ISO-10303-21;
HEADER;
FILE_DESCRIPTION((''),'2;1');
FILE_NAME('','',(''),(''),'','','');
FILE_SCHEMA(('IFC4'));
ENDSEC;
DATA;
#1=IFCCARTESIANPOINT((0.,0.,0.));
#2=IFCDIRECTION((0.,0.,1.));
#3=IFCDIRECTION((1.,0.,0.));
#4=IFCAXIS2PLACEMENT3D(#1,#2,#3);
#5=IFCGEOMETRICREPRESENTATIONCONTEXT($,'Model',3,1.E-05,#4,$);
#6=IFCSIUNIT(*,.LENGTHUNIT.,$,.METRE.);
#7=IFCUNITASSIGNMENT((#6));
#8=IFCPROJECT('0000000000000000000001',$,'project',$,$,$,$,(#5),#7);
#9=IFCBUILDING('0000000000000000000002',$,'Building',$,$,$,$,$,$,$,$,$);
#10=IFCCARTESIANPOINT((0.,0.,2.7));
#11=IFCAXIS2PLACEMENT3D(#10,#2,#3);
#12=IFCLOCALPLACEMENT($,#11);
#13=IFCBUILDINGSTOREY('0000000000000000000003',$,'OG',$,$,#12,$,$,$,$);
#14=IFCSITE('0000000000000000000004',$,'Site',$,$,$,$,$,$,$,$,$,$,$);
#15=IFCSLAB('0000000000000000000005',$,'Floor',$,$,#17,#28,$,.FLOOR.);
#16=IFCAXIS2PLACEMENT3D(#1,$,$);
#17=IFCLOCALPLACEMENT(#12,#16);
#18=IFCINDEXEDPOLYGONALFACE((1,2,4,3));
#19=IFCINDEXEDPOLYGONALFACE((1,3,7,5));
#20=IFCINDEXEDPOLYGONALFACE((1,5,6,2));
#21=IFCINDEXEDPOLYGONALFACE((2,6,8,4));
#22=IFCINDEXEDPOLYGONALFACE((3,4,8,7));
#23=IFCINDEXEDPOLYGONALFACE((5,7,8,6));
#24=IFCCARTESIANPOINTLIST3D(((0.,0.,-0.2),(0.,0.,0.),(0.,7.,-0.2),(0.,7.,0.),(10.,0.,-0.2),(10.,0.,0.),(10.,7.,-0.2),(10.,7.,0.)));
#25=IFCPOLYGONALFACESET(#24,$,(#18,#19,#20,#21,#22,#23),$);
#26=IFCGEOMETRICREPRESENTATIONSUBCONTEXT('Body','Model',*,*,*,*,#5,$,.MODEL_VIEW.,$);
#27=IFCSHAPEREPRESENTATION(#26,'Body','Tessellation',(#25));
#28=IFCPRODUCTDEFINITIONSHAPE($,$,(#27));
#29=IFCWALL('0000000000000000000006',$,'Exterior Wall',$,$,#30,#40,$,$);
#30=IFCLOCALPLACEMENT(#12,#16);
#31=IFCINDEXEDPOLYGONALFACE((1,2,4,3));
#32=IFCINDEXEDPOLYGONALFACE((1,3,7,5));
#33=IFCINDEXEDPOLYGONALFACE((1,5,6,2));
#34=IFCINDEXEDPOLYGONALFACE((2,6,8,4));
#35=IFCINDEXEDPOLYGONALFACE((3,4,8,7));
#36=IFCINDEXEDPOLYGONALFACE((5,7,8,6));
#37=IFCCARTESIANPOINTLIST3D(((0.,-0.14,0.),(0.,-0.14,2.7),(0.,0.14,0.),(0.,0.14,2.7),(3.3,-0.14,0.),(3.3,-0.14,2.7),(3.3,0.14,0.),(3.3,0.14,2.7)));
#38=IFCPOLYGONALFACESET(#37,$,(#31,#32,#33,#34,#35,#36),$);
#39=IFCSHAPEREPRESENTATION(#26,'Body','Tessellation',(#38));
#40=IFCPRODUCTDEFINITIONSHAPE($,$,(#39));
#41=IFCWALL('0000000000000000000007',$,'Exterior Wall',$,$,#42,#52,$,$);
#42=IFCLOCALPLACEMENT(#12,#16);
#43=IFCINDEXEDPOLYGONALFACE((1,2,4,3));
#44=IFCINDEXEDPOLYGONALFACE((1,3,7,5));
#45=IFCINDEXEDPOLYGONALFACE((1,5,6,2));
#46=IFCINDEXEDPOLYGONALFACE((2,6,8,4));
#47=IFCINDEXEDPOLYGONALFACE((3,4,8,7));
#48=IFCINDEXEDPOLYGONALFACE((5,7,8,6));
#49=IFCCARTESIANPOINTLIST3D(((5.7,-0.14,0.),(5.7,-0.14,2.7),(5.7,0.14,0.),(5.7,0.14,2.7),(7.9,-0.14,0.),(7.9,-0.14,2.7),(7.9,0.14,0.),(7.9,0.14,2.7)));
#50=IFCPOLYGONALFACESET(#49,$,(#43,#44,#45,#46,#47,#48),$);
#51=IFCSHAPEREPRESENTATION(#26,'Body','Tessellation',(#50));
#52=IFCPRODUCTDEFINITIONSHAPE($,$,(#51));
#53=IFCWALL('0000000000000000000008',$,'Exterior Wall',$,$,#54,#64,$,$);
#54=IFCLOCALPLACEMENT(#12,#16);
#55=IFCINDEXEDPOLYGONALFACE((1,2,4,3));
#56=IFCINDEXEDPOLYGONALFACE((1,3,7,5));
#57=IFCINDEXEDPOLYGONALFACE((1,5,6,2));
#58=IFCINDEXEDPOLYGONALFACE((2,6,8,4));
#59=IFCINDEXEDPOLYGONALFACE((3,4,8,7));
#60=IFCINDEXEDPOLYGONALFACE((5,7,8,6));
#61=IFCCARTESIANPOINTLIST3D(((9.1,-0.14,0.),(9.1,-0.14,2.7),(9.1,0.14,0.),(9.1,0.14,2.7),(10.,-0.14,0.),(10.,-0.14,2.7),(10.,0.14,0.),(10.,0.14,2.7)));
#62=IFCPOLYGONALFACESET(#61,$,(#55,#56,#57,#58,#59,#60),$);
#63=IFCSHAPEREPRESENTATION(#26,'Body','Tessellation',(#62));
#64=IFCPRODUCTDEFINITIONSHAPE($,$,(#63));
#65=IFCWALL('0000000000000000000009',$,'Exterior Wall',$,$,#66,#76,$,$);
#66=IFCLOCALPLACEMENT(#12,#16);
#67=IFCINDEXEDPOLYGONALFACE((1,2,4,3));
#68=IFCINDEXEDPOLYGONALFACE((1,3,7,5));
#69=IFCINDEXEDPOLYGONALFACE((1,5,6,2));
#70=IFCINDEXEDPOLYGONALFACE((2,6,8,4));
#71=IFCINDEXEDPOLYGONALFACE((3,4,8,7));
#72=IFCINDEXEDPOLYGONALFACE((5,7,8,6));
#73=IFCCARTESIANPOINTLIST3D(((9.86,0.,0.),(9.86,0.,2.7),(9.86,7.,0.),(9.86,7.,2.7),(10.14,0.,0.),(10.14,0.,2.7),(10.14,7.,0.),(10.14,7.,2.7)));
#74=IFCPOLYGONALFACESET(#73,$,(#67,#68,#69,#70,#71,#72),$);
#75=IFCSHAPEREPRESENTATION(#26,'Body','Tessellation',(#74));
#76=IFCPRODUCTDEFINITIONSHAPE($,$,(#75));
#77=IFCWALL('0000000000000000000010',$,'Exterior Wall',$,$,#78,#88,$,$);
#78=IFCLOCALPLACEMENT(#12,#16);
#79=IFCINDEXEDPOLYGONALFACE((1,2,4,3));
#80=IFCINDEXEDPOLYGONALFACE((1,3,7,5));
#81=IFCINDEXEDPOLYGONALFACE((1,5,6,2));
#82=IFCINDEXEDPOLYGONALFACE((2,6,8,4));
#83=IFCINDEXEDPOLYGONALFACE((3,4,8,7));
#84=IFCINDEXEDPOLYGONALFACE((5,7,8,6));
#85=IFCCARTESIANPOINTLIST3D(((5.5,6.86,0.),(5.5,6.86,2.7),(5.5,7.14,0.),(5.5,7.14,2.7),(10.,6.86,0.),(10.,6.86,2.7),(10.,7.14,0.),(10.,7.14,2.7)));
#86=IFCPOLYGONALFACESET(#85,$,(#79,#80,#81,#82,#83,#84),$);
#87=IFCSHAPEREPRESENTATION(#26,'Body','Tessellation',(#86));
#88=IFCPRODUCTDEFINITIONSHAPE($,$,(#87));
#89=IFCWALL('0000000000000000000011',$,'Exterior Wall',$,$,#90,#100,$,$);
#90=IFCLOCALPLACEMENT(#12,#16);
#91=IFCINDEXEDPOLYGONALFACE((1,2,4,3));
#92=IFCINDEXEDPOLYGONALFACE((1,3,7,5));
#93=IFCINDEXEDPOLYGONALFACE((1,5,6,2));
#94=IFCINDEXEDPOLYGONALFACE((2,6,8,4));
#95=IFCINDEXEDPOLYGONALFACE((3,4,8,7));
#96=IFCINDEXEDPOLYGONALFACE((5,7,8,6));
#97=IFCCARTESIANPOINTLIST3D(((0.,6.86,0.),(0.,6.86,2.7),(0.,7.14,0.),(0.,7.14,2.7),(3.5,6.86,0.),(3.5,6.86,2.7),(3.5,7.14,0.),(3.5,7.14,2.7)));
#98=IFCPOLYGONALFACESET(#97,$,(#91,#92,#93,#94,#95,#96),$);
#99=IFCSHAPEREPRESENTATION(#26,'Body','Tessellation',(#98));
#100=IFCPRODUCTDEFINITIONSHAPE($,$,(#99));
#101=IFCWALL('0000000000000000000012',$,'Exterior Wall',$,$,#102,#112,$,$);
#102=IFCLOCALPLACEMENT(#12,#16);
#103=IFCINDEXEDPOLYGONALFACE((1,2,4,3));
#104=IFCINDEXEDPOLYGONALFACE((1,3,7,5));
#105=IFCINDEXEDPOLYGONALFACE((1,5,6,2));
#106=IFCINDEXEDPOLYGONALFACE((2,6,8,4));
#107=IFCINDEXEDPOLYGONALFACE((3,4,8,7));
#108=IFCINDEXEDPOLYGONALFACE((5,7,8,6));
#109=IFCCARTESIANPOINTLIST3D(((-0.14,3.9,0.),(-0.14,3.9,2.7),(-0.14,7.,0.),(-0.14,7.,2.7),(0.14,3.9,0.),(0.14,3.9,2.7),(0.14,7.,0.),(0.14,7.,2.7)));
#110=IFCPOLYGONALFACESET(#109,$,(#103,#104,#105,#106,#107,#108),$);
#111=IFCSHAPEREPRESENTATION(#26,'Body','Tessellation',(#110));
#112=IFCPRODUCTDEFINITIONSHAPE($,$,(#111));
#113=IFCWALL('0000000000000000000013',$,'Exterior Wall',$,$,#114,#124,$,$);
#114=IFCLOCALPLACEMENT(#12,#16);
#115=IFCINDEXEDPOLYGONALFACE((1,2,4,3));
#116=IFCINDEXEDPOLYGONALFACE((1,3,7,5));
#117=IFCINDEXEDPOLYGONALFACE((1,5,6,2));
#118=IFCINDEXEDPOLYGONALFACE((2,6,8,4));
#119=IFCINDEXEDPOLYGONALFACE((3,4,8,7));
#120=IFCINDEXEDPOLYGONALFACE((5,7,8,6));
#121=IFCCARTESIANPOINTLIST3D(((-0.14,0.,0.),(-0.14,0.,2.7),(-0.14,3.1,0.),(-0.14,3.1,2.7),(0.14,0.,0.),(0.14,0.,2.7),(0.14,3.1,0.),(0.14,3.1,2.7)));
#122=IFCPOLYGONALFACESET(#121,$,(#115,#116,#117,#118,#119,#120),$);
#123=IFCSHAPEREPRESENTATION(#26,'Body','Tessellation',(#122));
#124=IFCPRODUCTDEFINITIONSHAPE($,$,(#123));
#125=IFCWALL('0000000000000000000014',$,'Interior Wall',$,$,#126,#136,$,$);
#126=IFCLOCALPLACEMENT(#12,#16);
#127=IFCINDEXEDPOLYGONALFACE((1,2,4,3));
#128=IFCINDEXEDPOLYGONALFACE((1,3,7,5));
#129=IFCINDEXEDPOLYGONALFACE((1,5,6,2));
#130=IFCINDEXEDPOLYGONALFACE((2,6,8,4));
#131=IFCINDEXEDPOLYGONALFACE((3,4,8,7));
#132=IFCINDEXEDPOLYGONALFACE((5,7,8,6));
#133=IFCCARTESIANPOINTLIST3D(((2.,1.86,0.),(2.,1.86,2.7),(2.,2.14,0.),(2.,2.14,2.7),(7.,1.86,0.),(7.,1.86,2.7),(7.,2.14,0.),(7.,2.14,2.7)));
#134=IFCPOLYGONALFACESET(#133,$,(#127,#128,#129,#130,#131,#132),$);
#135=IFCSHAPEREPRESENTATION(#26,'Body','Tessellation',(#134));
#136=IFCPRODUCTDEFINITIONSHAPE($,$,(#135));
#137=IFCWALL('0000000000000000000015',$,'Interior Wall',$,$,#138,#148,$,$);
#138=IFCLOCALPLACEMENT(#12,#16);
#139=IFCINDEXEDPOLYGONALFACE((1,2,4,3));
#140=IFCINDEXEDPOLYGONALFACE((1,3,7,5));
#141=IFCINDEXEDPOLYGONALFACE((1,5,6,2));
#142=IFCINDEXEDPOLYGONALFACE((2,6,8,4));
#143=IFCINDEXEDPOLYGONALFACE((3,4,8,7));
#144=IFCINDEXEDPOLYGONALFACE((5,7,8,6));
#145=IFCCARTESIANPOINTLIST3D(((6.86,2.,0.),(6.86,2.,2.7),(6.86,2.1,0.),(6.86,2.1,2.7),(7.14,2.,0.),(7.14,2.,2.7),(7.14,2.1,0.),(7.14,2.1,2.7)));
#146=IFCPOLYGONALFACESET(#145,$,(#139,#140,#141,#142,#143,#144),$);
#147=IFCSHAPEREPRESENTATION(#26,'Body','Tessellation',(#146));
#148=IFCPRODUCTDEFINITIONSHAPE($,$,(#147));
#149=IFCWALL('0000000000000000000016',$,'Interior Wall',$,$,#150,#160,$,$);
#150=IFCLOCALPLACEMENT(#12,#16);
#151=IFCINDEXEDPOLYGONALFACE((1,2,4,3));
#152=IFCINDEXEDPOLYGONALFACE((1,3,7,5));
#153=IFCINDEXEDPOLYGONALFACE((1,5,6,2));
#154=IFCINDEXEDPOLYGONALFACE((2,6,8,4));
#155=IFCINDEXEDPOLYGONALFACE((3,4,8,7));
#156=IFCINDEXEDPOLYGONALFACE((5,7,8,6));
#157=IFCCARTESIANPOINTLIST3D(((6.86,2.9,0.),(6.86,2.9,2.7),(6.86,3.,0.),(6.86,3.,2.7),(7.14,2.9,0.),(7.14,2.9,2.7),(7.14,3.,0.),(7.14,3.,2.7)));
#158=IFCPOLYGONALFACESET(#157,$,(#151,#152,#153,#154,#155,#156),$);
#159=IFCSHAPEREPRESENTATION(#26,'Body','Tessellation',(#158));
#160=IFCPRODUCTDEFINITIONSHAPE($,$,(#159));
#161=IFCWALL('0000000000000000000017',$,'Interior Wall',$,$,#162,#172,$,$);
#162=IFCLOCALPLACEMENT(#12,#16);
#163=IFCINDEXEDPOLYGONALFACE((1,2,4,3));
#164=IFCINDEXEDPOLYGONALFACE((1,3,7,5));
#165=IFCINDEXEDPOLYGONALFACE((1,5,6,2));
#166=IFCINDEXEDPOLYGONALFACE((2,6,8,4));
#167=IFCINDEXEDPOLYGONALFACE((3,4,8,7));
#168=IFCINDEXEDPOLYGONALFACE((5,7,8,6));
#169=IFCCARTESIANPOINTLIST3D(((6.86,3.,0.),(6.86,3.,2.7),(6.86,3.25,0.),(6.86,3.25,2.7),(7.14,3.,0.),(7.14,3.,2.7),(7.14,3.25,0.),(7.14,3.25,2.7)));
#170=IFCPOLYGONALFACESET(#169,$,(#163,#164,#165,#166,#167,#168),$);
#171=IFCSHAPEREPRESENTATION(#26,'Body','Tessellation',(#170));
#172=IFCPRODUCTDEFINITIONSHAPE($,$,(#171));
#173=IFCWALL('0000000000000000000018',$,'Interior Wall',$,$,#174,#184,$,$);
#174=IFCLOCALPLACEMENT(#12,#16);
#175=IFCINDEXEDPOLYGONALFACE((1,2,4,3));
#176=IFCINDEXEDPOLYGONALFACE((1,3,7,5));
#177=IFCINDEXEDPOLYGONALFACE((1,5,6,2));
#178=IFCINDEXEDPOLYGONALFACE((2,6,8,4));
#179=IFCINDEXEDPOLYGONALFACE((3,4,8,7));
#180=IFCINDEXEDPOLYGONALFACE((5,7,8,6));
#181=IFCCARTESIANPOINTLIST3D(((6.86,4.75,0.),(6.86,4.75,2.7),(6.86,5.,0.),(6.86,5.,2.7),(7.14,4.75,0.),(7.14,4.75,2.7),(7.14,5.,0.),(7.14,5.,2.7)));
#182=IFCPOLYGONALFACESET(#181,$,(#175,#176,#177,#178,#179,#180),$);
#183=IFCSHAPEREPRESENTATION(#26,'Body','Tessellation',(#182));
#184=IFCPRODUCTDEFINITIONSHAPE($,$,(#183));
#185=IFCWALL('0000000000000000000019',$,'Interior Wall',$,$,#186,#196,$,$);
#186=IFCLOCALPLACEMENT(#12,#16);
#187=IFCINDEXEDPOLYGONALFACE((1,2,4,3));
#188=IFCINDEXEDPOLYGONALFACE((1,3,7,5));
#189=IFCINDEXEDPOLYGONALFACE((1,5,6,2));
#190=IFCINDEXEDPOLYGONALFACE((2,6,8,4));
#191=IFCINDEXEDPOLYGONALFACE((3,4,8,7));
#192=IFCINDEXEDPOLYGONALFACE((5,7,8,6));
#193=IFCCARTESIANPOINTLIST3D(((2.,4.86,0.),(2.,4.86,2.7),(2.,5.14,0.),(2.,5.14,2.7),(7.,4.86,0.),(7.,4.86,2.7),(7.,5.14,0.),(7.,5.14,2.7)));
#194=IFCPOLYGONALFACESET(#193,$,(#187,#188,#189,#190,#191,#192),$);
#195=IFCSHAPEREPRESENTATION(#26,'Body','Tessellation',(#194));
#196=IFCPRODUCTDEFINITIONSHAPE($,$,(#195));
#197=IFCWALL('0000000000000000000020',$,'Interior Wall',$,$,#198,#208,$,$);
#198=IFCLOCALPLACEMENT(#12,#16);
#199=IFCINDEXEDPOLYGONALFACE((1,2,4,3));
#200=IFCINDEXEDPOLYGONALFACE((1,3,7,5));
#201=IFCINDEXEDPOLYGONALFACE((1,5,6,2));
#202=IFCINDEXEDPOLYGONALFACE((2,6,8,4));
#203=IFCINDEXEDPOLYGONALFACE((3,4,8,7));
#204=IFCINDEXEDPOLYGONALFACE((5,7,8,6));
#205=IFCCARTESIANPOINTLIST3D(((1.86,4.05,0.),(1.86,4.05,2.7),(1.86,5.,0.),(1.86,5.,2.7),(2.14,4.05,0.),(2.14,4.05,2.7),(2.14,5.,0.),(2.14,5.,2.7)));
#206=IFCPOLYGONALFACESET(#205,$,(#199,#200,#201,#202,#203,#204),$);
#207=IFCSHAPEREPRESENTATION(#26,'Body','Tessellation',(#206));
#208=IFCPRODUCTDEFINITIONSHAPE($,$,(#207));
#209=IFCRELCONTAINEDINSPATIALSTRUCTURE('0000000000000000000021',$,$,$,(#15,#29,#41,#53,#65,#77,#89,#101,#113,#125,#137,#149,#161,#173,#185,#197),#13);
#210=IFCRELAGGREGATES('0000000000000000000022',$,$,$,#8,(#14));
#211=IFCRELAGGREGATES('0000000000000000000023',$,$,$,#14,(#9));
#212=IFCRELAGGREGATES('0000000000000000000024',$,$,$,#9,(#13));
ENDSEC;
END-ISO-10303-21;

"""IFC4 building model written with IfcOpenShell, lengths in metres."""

from ifc_helpers import new_model, si_unit, frame, origin_with_axes, place, context, subcontext, project, spatial, indexed_curve, outline, extrude, element, save


model = new_model("IFC4")

# Units and contexts
model_context = context("Model", 3, precision=1e-05, world=origin_with_axes())
body_context = subcontext(model_context, "Body", "Model", "MODEL_VIEW")
ifc_project = project(units=[si_unit("LENGTHUNIT", "METRE")], contexts=[model_context])

# Site, building, storey
site = spatial("IfcSite", under=ifc_project, Name="Site")
building = spatial("IfcBuilding", under=site, Name="Building")
storey_placement = place(None, frame((0.0, 0.0, 2.7), z_axis=(0.0, 0.0, 1.0), x_axis=(1.0, 0.0, 0.0)))
storey = spatial("IfcBuildingStorey", under=building, at=storey_placement, Name="OG")

# Slab
slab_placement = place(storey_placement, frame((0.0, 0.0, -0.2), z_axis=(0.0, 0.0, 1.0), x_axis=(1.0, 0.0, 0.0)))
element("IfcSlab", 1, at=slab_placement, inside=storey, Name="Floor", PredefinedType="FLOOR", context=body_context, shape_type="SweptSolid", body=[
    extrude(outline(indexed_curve([(0.0, 0.0), (10.0, 0.0), (10.0, 7.0), (0.0, 7.0)])), None, (0.0, 0.0, 1.0), 0.2),
])

# Walls
wall_1_placement = place(storey_placement, origin_with_axes())
element("IfcWall", 2, at=wall_1_placement, inside=storey, Name="Exterior Wall", context=body_context, shape_type="SweptSolid", body=[
    extrude(outline(indexed_curve([(0.0, 0.0), (0.0, 0.28), (3.3, 0.28), (3.3, 0.0), (0.0, 0.0)], self_intersect=False)), frame((0.0, -0.14, 0.0), z_axis=(0.0, 0.0, 1.0), x_axis=(1.0, 0.0, 0.0)), (0.0, 0.0, 1.0), 2.7),
])
wall_2_placement = place(storey_placement, frame((5.7, 0.0, 0.0), z_axis=(0.0, 0.0, 1.0), x_axis=(1.0, 0.0, 0.0)))
element("IfcWall", 3, at=wall_2_placement, inside=storey, Name="Exterior Wall", context=body_context, shape_type="SweptSolid", body=[
    extrude(outline(indexed_curve([(0.0, 0.0), (0.0, 0.28), (2.2, 0.28), (2.2, 0.0), (0.0, 0.0)], self_intersect=False)), frame((0.0, -0.14, 0.0), z_axis=(0.0, 0.0, 1.0), x_axis=(1.0, 0.0, 0.0)), (0.0, 0.0, 1.0), 2.7),
])
wall_3_placement = place(storey_placement, frame((9.1, 0.0, 0.0), z_axis=(0.0, 0.0, 1.0), x_axis=(1.0, 0.0, 0.0)))
element("IfcWall", 4, at=wall_3_placement, inside=storey, Name="Exterior Wall", context=body_context, shape_type="SweptSolid", body=[
    extrude(outline(indexed_curve([(0.0, 0.0), (0.0, 0.28), (0.9, 0.28), (0.9, 0.0), (0.0, 0.0)], self_intersect=False)), frame((0.0, -0.14, 0.0), z_axis=(0.0, 0.0, 1.0), x_axis=(1.0, 0.0, 0.0)), (0.0, 0.0, 1.0), 2.7),
])
wall_4_placement = place(storey_placement, frame((10.0, 0.0, 0.0), z_axis=(0.0, 0.0, 1.0), x_axis=(0.0, 1.0, 0.0)))
element("IfcWall", 5, at=wall_4_placement, inside=storey, Name="Exterior Wall", context=body_context, shape_type="SweptSolid", body=[
    extrude(outline(indexed_curve([(0.0, 0.0), (0.0, 0.28), (7.0, 0.28), (7.0, 0.0), (0.0, 0.0)], self_intersect=False)), frame((0.0, -0.14, 0.0), z_axis=(0.0, 0.0, 1.0), x_axis=(1.0, 0.0, 0.0)), (0.0, 0.0, 1.0), 2.7),
])
wall_5_placement = place(storey_placement, frame((10.0, 7.0, 0.0), z_axis=(0.0, 0.0, 1.0), x_axis=(-1.0, 0.0, 0.0)))
element("IfcWall", 6, at=wall_5_placement, inside=storey, Name="Exterior Wall", context=body_context, shape_type="SweptSolid", body=[
    extrude(outline(indexed_curve([(0.0, 0.0), (0.0, 0.28), (4.5, 0.28), (4.5, 0.0), (0.0, 0.0)], self_intersect=False)), frame((0.0, -0.14, 0.0), z_axis=(0.0, 0.0, 1.0), x_axis=(1.0, 0.0, 0.0)), (0.0, 0.0, 1.0), 2.7),
])
wall_6_placement = place(storey_placement, frame((3.5, 7.0, 0.0), z_axis=(0.0, 0.0, 1.0), x_axis=(-1.0, 0.0, 0.0)))
element("IfcWall", 7, at=wall_6_placement, inside=storey, Name="Exterior Wall", context=body_context, shape_type="SweptSolid", body=[
    extrude(outline(indexed_curve([(0.0, 0.0), (0.0, 0.28), (3.5, 0.28), (3.5, 0.0), (0.0, 0.0)], self_intersect=False)), frame((0.0, -0.14, 0.0), z_axis=(0.0, 0.0, 1.0), x_axis=(1.0, 0.0, 0.0)), (0.0, 0.0, 1.0), 2.7),
])
for number, where, z_axis, x_axis, name in (
    (8, (0.0, 7.0, 0.0), (0.0, 0.0, 1.0), (0.0, -1.0, 0.0), "Exterior Wall"),
    (9, (0.0, 3.1, 0.0), (0.0, 0.0, 1.0), (0.0, -1.0, 0.0), "Exterior Wall"),
):
    element("IfcWall", number, at=place(storey_placement, frame(where, z_axis=z_axis, x_axis=x_axis)), inside=storey, Name=name, context=body_context, shape_type="SweptSolid", body=[
        extrude(outline(indexed_curve([(0.0, 0.0), (0.0, 0.28), (3.1, 0.28), (3.1, 0.0), (0.0, 0.0)], self_intersect=False)), frame((0.0, -0.14, 0.0), z_axis=(0.0, 0.0, 1.0), x_axis=(1.0, 0.0, 0.0)), (0.0, 0.0, 1.0), 2.7),
    ])
wall_7_placement = place(storey_placement, frame((2.0, 2.0, 0.0), z_axis=(0.0, 0.0, 1.0), x_axis=(1.0, 0.0, 0.0)))
element("IfcWall", 10, at=wall_7_placement, inside=storey, Name="Interior Wall", context=body_context, shape_type="SweptSolid", body=[
    extrude(outline(indexed_curve([(0.0, 0.0), (0.0, 0.28), (5.0, 0.28), (5.0, 0.0), (0.0, 0.0)], self_intersect=False)), frame((0.0, -0.14, 0.0), z_axis=(0.0, 0.0, 1.0), x_axis=(1.0, 0.0, 0.0)), (0.0, 0.0, 1.0), 2.7),
])
for number, where, z_axis, x_axis, name in (
    (11, (7.0, 2.0, 0.0), (0.0, 0.0, 1.0), (0.0, 1.0, 0.0), "Interior Wall"),
    (12, (7.0, 2.9, 0.0), (0.0, 0.0, 1.0), (0.0, 1.0, 0.0), "Interior Wall"),
):
    element("IfcWall", number, at=place(storey_placement, frame(where, z_axis=z_axis, x_axis=x_axis)), inside=storey, Name=name, context=body_context, shape_type="SweptSolid", body=[
        extrude(outline(indexed_curve([(0.0, 0.0), (0.0, 0.28), (0.1, 0.28), (0.1, 0.0), (0.0, 0.0)], self_intersect=False)), frame((0.0, -0.14, 0.0), z_axis=(0.0, 0.0, 1.0), x_axis=(1.0, 0.0, 0.0)), (0.0, 0.0, 1.0), 2.7),
    ])
for number, where, z_axis, x_axis, name in (
    (13, (7.0, 3.0, 0.0), (0.0, 0.0, 1.0), (0.0, 1.0, 0.0), "Interior Wall"),
    (14, (7.0, 4.75, 0.0), (0.0, 0.0, 1.0), (0.0, 1.0, 0.0), "Interior Wall"),
):
    element("IfcWall", number, at=place(storey_placement, frame(where, z_axis=z_axis, x_axis=x_axis)), inside=storey, Name=name, context=body_context, shape_type="SweptSolid", body=[
        extrude(outline(indexed_curve([(0.0, 0.0), (0.0, 0.28), (0.25, 0.28), (0.25, 0.0), (0.0, 0.0)], self_intersect=False)), frame((0.0, -0.14, 0.0), z_axis=(0.0, 0.0, 1.0), x_axis=(1.0, 0.0, 0.0)), (0.0, 0.0, 1.0), 2.7),
    ])
wall_8_placement = place(storey_placement, frame((7.0, 5.0, 0.0), z_axis=(0.0, 0.0, 1.0), x_axis=(-1.0, 0.0, 0.0)))
element("IfcWall", 15, at=wall_8_placement, inside=storey, Name="Interior Wall", context=body_context, shape_type="SweptSolid", body=[
    extrude(outline(indexed_curve([(0.0, 0.0), (0.0, 0.28), (5.0, 0.28), (5.0, 0.0), (0.0, 0.0)], self_intersect=False)), frame((0.0, -0.14, 0.0), z_axis=(0.0, 0.0, 1.0), x_axis=(1.0, 0.0, 0.0)), (0.0, 0.0, 1.0), 2.7),
])
for number, where, z_axis, x_axis, name in (
    (16, (2.0, 5.0, 0.0), (0.0, 0.0, 1.0), (0.0, -1.0, 0.0), "Interior Wall"),
):
    element("IfcWall", number, at=place(storey_placement, frame(where, z_axis=z_axis, x_axis=x_axis)), inside=storey, Name=name, context=body_context, shape_type="SweptSolid", body=[
        extrude(outline(indexed_curve([(0.0, 0.0), (0.0, 0.28), (0.95, 0.28), (0.95, 0.0), (0.0, 0.0)], self_intersect=False)), frame((0.0, -0.14, 0.0), z_axis=(0.0, 0.0, 1.0), x_axis=(1.0, 0.0, 0.0)), (0.0, 0.0, 1.0), 2.7),
    ])

save(model, "model.ifc")
